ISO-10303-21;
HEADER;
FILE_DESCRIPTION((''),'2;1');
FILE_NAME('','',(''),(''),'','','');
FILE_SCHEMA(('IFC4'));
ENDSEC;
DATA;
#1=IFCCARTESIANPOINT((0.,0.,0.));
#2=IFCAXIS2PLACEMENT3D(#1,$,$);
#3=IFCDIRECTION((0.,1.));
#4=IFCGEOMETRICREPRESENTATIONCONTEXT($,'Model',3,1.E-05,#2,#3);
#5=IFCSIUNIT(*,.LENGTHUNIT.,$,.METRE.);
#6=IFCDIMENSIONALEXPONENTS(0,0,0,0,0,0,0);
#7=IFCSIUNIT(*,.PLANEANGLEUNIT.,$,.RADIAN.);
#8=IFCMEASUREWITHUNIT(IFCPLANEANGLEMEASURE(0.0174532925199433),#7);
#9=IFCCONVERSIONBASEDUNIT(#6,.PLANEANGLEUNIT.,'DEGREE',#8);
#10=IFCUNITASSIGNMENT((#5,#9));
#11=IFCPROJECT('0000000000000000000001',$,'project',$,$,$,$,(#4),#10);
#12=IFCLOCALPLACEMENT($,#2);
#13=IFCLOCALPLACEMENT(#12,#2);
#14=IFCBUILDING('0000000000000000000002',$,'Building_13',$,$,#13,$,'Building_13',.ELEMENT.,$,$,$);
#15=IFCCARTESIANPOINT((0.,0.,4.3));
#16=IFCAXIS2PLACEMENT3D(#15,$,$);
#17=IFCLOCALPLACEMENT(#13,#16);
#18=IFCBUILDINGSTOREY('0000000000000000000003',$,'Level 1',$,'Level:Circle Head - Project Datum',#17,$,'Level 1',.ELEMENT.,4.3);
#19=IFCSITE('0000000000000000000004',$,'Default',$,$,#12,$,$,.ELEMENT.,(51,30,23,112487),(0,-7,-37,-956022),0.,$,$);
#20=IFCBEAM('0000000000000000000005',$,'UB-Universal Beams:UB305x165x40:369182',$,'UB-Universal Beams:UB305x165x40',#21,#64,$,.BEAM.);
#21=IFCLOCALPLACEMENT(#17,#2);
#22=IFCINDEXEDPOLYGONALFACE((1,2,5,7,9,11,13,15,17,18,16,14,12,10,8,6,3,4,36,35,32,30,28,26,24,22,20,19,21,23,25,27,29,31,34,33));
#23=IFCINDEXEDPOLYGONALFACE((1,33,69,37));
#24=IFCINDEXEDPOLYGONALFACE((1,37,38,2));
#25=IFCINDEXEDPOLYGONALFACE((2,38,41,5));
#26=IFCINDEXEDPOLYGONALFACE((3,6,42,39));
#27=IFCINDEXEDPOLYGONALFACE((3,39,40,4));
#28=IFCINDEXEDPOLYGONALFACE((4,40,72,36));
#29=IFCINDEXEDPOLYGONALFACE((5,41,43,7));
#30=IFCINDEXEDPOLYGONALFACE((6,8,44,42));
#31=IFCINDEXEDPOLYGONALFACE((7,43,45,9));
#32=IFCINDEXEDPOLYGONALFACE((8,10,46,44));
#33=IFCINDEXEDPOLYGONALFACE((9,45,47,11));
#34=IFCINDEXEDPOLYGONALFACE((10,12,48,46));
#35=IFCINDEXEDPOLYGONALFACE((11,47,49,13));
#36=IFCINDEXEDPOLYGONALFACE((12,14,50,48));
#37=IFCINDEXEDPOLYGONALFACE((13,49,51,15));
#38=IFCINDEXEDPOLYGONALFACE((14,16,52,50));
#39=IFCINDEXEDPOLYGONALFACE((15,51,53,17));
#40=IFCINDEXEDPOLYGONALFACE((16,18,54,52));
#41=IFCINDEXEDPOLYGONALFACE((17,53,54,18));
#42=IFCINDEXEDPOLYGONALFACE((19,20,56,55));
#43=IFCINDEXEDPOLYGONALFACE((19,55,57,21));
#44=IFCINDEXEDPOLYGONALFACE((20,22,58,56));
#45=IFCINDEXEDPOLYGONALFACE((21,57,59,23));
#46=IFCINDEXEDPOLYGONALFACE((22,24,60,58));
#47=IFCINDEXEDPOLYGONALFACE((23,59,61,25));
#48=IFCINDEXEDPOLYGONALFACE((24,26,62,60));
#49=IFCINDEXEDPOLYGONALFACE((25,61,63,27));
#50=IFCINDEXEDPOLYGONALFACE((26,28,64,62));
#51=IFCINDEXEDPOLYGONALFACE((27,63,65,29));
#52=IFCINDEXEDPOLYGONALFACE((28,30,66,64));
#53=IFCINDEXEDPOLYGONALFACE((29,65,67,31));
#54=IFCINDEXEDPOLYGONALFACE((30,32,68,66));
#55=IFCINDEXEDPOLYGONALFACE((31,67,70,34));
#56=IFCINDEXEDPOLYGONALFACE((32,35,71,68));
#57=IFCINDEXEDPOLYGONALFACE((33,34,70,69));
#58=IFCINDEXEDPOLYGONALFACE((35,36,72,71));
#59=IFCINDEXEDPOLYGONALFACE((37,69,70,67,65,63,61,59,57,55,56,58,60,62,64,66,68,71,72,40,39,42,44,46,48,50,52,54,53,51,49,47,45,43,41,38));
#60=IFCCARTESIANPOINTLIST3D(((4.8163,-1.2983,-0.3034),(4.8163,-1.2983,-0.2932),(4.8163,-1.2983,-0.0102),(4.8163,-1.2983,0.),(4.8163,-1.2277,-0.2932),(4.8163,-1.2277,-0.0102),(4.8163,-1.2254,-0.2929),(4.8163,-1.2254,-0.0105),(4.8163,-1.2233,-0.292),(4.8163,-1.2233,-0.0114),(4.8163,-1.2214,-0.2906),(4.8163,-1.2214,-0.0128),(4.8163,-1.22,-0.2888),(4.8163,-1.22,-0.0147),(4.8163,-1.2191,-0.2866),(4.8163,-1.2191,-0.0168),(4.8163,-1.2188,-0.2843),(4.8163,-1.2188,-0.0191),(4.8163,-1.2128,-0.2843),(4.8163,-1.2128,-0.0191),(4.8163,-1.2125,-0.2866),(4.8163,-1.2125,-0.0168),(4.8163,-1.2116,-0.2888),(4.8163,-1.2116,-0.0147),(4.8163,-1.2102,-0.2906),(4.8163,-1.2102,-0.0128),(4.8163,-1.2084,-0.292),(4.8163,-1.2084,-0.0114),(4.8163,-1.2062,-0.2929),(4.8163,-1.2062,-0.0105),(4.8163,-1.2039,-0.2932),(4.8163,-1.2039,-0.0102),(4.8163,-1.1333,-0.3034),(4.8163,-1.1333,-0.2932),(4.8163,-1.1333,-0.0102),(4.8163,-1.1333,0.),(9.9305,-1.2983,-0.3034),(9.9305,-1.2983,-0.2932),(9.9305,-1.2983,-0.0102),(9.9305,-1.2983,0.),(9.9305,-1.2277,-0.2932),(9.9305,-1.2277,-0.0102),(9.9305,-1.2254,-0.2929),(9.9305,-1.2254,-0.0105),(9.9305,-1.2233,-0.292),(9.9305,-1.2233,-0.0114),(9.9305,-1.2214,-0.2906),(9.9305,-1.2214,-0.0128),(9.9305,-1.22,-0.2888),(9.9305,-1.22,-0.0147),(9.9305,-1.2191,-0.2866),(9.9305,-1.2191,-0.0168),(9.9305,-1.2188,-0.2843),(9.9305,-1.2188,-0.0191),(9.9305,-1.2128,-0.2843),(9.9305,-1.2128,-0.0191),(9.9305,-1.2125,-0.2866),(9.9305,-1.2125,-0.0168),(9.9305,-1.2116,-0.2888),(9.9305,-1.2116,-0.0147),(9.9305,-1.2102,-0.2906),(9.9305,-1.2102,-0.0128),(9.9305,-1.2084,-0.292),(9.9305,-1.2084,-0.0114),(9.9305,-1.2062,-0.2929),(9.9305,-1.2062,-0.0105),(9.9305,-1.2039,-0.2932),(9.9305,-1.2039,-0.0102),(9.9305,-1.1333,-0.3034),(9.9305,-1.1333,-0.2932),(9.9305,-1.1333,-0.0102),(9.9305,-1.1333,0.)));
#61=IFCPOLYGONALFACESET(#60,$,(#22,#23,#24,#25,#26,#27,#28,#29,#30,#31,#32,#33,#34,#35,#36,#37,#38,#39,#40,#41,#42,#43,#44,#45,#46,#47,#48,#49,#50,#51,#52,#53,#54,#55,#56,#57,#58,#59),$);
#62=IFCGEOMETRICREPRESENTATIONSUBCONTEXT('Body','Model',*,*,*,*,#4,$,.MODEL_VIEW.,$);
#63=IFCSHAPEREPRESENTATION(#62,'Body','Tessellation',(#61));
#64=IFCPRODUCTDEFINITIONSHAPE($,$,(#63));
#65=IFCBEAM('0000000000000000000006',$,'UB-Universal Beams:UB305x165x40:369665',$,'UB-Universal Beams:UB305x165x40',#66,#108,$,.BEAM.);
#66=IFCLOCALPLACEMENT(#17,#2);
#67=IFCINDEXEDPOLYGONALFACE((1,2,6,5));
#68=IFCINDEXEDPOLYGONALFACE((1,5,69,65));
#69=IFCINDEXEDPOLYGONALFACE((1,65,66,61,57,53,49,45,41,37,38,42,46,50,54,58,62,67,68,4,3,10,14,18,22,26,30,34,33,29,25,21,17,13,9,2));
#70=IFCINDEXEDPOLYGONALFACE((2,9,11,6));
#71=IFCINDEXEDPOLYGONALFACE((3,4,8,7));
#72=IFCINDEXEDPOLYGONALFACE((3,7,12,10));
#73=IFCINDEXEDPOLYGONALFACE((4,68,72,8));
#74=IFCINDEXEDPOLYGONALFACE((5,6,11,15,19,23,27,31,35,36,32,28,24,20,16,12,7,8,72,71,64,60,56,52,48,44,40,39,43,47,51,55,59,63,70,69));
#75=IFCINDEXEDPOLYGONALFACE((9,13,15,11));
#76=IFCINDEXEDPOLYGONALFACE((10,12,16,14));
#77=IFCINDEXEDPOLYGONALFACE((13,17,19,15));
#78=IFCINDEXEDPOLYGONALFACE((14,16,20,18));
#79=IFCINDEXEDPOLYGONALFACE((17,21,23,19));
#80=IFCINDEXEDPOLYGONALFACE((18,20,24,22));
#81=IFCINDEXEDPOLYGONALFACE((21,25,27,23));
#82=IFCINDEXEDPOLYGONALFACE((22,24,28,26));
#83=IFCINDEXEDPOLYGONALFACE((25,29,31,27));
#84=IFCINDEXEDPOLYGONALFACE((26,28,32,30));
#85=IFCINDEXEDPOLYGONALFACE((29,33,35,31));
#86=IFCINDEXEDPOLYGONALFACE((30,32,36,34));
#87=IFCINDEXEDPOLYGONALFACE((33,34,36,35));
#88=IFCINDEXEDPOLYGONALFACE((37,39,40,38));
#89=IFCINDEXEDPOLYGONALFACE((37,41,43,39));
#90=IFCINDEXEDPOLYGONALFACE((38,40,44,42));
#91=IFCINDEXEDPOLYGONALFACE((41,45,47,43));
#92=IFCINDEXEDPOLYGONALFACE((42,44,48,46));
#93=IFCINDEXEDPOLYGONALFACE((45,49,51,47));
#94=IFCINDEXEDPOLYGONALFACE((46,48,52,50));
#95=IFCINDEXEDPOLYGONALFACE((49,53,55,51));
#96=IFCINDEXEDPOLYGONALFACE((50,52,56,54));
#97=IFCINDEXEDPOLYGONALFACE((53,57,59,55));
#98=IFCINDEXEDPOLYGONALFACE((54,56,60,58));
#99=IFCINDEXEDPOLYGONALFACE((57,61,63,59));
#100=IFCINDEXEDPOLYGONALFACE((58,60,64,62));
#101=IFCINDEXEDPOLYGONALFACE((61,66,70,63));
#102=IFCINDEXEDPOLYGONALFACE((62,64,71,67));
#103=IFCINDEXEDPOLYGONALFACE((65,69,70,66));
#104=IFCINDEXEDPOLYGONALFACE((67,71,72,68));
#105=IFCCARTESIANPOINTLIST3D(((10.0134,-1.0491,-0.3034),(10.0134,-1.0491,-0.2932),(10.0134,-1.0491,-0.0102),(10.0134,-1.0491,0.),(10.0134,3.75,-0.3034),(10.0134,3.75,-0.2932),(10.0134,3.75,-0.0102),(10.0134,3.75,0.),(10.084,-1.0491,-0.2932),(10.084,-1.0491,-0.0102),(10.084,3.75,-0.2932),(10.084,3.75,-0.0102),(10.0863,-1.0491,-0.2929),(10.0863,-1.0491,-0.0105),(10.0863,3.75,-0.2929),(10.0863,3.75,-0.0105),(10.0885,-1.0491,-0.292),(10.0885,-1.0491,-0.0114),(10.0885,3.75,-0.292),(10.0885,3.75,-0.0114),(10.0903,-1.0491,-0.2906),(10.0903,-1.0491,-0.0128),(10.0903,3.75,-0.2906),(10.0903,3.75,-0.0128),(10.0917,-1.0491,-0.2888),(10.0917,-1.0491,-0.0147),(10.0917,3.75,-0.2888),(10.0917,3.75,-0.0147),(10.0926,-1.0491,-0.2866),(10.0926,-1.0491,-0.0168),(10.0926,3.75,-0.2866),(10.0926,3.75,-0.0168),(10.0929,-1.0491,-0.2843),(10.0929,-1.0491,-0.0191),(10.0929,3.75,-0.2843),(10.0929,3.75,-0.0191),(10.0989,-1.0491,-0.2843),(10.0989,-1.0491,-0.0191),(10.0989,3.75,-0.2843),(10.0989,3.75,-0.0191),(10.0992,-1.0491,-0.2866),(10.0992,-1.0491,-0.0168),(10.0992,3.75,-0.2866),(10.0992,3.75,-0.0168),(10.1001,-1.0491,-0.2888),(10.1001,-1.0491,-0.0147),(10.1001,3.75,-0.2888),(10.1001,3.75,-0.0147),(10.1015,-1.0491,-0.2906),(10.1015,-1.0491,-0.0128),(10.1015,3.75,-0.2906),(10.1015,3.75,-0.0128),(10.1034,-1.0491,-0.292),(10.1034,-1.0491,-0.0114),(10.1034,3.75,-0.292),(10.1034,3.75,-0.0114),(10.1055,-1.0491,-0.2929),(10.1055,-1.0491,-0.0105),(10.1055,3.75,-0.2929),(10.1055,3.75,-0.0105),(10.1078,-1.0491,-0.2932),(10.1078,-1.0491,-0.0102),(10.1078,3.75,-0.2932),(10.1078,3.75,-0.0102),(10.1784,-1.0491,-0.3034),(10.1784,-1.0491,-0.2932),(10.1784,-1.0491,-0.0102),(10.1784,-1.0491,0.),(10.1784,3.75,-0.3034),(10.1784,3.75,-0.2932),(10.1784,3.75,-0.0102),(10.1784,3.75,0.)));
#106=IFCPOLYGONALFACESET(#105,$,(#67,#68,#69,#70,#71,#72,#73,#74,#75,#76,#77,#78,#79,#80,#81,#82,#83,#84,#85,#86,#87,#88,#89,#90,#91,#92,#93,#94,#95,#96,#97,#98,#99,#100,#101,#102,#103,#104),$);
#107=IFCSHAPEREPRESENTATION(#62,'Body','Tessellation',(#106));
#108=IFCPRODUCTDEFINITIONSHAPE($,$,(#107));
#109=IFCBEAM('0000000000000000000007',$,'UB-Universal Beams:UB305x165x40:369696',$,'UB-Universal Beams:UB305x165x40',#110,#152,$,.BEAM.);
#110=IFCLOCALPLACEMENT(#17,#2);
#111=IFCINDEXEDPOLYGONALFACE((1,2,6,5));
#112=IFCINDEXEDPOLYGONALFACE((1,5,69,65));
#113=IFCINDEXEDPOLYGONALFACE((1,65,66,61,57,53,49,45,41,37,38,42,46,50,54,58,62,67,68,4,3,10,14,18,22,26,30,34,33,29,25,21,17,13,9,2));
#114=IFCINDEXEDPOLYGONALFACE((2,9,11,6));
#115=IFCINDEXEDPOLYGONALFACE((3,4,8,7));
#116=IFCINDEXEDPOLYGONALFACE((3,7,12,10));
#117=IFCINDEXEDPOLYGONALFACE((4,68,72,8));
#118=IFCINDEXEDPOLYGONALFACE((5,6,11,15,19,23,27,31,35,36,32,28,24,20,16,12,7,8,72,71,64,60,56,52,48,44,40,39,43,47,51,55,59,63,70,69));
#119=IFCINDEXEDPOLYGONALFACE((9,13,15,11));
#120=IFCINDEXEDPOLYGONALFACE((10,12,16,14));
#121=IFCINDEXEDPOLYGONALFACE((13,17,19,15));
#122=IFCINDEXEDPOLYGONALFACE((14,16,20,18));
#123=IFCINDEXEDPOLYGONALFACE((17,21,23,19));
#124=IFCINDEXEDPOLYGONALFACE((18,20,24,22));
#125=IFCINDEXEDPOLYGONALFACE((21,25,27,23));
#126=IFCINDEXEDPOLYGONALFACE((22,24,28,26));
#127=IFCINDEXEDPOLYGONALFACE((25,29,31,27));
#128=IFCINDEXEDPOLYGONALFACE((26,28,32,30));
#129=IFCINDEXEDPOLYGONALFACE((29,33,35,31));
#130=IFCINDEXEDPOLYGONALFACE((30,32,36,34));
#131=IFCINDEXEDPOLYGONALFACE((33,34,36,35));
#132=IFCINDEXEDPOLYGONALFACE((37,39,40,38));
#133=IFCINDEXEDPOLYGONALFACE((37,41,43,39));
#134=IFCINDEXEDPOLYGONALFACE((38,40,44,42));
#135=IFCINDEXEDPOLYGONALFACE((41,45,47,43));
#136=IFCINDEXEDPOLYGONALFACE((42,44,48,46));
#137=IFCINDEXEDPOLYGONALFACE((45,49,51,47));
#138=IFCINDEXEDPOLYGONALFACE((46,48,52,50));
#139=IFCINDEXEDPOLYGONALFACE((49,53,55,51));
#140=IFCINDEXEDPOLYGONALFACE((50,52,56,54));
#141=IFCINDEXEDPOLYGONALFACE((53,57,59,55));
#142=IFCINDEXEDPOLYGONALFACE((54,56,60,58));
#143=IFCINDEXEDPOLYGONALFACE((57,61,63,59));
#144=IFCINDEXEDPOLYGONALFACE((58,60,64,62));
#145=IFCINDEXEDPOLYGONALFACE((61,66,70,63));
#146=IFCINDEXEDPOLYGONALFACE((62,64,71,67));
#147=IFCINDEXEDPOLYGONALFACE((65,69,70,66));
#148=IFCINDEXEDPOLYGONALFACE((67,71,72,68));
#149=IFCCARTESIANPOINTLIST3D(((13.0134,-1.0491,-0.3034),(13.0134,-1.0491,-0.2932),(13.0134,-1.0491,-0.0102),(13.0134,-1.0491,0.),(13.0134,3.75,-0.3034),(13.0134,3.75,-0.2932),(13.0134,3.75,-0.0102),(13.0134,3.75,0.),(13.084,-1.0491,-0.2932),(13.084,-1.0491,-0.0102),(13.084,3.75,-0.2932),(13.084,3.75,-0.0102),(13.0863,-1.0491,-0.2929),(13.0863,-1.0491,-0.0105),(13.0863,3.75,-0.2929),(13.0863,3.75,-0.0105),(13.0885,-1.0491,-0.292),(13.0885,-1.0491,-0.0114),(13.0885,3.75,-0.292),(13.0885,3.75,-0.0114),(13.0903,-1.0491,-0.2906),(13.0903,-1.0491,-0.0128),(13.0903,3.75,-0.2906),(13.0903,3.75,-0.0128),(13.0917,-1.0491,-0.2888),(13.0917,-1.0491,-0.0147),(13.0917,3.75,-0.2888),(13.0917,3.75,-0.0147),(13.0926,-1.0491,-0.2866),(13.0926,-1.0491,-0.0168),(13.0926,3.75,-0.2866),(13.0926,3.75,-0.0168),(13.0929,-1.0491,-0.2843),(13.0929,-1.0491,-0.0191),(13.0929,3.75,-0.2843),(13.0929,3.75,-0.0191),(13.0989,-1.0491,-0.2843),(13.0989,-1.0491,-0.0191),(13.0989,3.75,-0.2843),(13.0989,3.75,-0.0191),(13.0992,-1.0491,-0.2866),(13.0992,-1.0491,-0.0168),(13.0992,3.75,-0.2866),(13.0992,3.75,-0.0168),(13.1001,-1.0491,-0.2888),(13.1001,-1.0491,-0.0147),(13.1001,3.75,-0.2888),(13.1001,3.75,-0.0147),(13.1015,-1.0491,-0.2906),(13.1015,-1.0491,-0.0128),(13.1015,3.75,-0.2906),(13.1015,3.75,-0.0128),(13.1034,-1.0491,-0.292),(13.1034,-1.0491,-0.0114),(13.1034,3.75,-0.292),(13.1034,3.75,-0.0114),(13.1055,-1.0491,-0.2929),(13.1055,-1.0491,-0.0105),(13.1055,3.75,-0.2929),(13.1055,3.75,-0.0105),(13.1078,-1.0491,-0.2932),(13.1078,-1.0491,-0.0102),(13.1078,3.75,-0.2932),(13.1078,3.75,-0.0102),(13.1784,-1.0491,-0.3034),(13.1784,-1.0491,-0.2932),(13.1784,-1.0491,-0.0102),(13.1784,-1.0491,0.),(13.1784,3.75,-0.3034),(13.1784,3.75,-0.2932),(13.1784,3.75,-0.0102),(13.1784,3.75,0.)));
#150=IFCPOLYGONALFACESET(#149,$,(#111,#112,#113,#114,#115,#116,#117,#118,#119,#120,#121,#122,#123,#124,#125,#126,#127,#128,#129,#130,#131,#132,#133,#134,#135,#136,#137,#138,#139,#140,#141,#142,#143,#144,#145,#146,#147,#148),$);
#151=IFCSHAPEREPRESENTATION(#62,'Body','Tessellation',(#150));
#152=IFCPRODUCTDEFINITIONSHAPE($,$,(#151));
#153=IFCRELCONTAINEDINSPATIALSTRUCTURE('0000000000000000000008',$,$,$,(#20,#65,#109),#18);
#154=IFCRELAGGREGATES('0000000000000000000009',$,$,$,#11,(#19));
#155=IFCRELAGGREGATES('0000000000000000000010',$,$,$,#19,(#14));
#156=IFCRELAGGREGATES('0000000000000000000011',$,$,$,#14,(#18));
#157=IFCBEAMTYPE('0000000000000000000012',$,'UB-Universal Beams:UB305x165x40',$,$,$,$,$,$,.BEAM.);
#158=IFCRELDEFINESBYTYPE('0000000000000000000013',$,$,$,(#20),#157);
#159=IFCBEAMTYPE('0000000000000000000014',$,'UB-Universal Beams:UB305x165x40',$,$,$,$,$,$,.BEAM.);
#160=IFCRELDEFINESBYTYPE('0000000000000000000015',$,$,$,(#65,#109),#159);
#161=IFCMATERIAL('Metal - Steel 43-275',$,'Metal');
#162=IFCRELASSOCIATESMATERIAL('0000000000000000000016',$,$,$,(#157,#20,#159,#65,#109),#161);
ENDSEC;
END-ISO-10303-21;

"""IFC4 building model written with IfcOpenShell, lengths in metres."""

from ifc_helpers import new_model, entity, si_unit, converted_unit, direction, frame, origin, place, context, subcontext, project, spatial, line, arc, indexed_curve, outline, extrude, source, transform, mapped, material, type_object, type_shapes, element, save


model = new_model("IFC4")

# Units and contexts
model_context = context("Model", 3, precision=1e-05, world=origin(), true_north=direction((0.0, 1.0)))
body_context = subcontext(model_context, "Body", "Model", "MODEL_VIEW")
ifc_project = project(units=[si_unit("LENGTHUNIT", "METRE"), converted_unit("PLANEANGLEUNIT", "DEGREE", entity("IfcPlaneAngleMeasure", 0.0174532925199433), si_unit("PLANEANGLEUNIT", "RADIAN"), dimensions=[0, 0, 0, 0, 0, 0, 0])], contexts=[model_context])

# Site, building, storey
site_placement = place(None, origin())
site = spatial("IfcSite", under=ifc_project, at=site_placement, Name="Default", CompositionType="ELEMENT", RefLatitude=(51, 30, 23, 112487), RefLongitude=(0, -7, -37, -956022), RefElevation=0.0)
building_placement = place(site_placement, origin())
building = spatial("IfcBuilding", under=site, at=building_placement, Name="Building_13", LongName="Building_13", CompositionType="ELEMENT")
storey_placement = place(building_placement, frame((0.0, 0.0, 4.3)))
storey = spatial("IfcBuildingStorey", under=building, at=storey_placement, Name="Level 1", ObjectType="Level:Circle Head - Project Datum", LongName="Level 1", CompositionType="ELEMENT", Elevation=4.3)

# Beams
ifc_material_1 = material(Name="Metal - Steel 43-275", Category="Metal")
beam_type_1 = type_object("IfcBeamType", Name="UB-Universal Beams:UB305x165x40", PredefinedType="BEAM", material=ifc_material_1)
shared_shape_1 = source(origin(), body_context, "Body", "SweptSolid", [
    extrude(outline(indexed_curve([(-0.0825, -0.1415), (-0.0825, -0.1517), (0.0825, -0.1517), (0.0825, -0.1415), (0.0119, -0.1415), (0.0056, -0.1389), (0.003, -0.1326), (0.003, 0.1326), (0.0056, 0.1389), (0.0119, 0.1415), (0.0825, 0.1415), (0.0825, 0.1517), (-0.0825, 0.1517), (-0.0825, 0.1415), (-0.0119, 0.1415), (-0.0056, 0.1389), (-0.003, 0.1326), (-0.003, -0.1326), (-0.0056, -0.1389), (-0.0119, -0.1415)], segments=[line(1, 2, 3, 4, 5), arc(5, 6, 7), line(7, 8), arc(8, 9, 10), line(10, 11, 12, 13, 14, 15), arc(15, 16, 17), line(17, 18), arc(18, 19, 20), line(20, 1)], self_intersect=False)), frame((-2.5571, 0.0, 0.0), z_axis=(-1.0, 0.0, 0.0), x_axis=(0.0, -1.0, 0.0)), (0.0, 0.0, -1.0), 5.1142),
])
type_shapes(beam_type_1, [shared_shape_1])
beam_1_placement = place(storey_placement, frame((7.3734, -1.2158, -0.1517), z_axis=(0.0, 0.0, 1.0), x_axis=(-1.0, 0.0, 0.0)))
element("IfcBeam", 1, at=beam_1_placement, inside=storey, type_object=beam_type_1, material=ifc_material_1, Name="UB-Universal Beams:UB305x165x40:369182", ObjectType="UB-Universal Beams:UB305x165x40", PredefinedType="BEAM", context=body_context, shape_type="MappedRepresentation", body=[
    mapped(shared_shape_1, transform((0.0, 0.0, 0.0), scale=1.0)),
])
beam_type_2 = type_object("IfcBeamType", Name="UB-Universal Beams:UB305x165x40", PredefinedType="BEAM", material=ifc_material_1)
shared_shape_2 = source(origin(), body_context, "Body", "SweptSolid", [
    extrude(outline(indexed_curve([(-0.0825, -0.1415), (-0.0825, -0.1517), (0.0825, -0.1517), (0.0825, -0.1415), (0.0119, -0.1415), (0.0056, -0.1389), (0.003, -0.1326), (0.003, 0.1326), (0.0056, 0.1389), (0.0119, 0.1415), (0.0825, 0.1415), (0.0825, 0.1517), (-0.0825, 0.1517), (-0.0825, 0.1415), (-0.0119, 0.1415), (-0.0056, 0.1389), (-0.003, 0.1326), (-0.003, -0.1326), (-0.0056, -0.1389), (-0.0119, -0.1415)], segments=[line(1, 2, 3, 4, 5), arc(5, 6, 7), line(7, 8), arc(8, 9, 10), line(10, 11, 12, 13, 14, 15), arc(15, 16, 17), line(17, 18), arc(18, 19, 20), line(20, 1)], self_intersect=False)), frame((-2.3996, 0.0, 0.0), z_axis=(-1.0, 0.0, 0.0), x_axis=(0.0, -1.0, 0.0)), (0.0, 0.0, -1.0), 4.7991),
])
type_shapes(beam_type_2, [shared_shape_2])
for number, where, z_axis, x_axis, name in (
    (2, (10.0959, 1.3504, -0.1517), (0.0, 0.0, 1.0), (0.0, 1.0, 0.0), "UB-Universal Beams:UB305x165x40:369665"),
    (3, (13.0959, 1.3504, -0.1517), (0.0, 0.0, 1.0), (0.0, -1.0, 0.0), "UB-Universal Beams:UB305x165x40:369696"),
):
    element("IfcBeam", number, at=place(storey_placement, frame(where, z_axis=z_axis, x_axis=x_axis)), inside=storey, type_object=beam_type_2, material=ifc_material_1, Name=name, ObjectType="UB-Universal Beams:UB305x165x40", PredefinedType="BEAM", context=body_context, shape_type="MappedRepresentation", body=[
        mapped(shared_shape_2, transform((0.0, 0.0, 0.0), scale=1.0)),
    ])

save(model, "model.ifc")
